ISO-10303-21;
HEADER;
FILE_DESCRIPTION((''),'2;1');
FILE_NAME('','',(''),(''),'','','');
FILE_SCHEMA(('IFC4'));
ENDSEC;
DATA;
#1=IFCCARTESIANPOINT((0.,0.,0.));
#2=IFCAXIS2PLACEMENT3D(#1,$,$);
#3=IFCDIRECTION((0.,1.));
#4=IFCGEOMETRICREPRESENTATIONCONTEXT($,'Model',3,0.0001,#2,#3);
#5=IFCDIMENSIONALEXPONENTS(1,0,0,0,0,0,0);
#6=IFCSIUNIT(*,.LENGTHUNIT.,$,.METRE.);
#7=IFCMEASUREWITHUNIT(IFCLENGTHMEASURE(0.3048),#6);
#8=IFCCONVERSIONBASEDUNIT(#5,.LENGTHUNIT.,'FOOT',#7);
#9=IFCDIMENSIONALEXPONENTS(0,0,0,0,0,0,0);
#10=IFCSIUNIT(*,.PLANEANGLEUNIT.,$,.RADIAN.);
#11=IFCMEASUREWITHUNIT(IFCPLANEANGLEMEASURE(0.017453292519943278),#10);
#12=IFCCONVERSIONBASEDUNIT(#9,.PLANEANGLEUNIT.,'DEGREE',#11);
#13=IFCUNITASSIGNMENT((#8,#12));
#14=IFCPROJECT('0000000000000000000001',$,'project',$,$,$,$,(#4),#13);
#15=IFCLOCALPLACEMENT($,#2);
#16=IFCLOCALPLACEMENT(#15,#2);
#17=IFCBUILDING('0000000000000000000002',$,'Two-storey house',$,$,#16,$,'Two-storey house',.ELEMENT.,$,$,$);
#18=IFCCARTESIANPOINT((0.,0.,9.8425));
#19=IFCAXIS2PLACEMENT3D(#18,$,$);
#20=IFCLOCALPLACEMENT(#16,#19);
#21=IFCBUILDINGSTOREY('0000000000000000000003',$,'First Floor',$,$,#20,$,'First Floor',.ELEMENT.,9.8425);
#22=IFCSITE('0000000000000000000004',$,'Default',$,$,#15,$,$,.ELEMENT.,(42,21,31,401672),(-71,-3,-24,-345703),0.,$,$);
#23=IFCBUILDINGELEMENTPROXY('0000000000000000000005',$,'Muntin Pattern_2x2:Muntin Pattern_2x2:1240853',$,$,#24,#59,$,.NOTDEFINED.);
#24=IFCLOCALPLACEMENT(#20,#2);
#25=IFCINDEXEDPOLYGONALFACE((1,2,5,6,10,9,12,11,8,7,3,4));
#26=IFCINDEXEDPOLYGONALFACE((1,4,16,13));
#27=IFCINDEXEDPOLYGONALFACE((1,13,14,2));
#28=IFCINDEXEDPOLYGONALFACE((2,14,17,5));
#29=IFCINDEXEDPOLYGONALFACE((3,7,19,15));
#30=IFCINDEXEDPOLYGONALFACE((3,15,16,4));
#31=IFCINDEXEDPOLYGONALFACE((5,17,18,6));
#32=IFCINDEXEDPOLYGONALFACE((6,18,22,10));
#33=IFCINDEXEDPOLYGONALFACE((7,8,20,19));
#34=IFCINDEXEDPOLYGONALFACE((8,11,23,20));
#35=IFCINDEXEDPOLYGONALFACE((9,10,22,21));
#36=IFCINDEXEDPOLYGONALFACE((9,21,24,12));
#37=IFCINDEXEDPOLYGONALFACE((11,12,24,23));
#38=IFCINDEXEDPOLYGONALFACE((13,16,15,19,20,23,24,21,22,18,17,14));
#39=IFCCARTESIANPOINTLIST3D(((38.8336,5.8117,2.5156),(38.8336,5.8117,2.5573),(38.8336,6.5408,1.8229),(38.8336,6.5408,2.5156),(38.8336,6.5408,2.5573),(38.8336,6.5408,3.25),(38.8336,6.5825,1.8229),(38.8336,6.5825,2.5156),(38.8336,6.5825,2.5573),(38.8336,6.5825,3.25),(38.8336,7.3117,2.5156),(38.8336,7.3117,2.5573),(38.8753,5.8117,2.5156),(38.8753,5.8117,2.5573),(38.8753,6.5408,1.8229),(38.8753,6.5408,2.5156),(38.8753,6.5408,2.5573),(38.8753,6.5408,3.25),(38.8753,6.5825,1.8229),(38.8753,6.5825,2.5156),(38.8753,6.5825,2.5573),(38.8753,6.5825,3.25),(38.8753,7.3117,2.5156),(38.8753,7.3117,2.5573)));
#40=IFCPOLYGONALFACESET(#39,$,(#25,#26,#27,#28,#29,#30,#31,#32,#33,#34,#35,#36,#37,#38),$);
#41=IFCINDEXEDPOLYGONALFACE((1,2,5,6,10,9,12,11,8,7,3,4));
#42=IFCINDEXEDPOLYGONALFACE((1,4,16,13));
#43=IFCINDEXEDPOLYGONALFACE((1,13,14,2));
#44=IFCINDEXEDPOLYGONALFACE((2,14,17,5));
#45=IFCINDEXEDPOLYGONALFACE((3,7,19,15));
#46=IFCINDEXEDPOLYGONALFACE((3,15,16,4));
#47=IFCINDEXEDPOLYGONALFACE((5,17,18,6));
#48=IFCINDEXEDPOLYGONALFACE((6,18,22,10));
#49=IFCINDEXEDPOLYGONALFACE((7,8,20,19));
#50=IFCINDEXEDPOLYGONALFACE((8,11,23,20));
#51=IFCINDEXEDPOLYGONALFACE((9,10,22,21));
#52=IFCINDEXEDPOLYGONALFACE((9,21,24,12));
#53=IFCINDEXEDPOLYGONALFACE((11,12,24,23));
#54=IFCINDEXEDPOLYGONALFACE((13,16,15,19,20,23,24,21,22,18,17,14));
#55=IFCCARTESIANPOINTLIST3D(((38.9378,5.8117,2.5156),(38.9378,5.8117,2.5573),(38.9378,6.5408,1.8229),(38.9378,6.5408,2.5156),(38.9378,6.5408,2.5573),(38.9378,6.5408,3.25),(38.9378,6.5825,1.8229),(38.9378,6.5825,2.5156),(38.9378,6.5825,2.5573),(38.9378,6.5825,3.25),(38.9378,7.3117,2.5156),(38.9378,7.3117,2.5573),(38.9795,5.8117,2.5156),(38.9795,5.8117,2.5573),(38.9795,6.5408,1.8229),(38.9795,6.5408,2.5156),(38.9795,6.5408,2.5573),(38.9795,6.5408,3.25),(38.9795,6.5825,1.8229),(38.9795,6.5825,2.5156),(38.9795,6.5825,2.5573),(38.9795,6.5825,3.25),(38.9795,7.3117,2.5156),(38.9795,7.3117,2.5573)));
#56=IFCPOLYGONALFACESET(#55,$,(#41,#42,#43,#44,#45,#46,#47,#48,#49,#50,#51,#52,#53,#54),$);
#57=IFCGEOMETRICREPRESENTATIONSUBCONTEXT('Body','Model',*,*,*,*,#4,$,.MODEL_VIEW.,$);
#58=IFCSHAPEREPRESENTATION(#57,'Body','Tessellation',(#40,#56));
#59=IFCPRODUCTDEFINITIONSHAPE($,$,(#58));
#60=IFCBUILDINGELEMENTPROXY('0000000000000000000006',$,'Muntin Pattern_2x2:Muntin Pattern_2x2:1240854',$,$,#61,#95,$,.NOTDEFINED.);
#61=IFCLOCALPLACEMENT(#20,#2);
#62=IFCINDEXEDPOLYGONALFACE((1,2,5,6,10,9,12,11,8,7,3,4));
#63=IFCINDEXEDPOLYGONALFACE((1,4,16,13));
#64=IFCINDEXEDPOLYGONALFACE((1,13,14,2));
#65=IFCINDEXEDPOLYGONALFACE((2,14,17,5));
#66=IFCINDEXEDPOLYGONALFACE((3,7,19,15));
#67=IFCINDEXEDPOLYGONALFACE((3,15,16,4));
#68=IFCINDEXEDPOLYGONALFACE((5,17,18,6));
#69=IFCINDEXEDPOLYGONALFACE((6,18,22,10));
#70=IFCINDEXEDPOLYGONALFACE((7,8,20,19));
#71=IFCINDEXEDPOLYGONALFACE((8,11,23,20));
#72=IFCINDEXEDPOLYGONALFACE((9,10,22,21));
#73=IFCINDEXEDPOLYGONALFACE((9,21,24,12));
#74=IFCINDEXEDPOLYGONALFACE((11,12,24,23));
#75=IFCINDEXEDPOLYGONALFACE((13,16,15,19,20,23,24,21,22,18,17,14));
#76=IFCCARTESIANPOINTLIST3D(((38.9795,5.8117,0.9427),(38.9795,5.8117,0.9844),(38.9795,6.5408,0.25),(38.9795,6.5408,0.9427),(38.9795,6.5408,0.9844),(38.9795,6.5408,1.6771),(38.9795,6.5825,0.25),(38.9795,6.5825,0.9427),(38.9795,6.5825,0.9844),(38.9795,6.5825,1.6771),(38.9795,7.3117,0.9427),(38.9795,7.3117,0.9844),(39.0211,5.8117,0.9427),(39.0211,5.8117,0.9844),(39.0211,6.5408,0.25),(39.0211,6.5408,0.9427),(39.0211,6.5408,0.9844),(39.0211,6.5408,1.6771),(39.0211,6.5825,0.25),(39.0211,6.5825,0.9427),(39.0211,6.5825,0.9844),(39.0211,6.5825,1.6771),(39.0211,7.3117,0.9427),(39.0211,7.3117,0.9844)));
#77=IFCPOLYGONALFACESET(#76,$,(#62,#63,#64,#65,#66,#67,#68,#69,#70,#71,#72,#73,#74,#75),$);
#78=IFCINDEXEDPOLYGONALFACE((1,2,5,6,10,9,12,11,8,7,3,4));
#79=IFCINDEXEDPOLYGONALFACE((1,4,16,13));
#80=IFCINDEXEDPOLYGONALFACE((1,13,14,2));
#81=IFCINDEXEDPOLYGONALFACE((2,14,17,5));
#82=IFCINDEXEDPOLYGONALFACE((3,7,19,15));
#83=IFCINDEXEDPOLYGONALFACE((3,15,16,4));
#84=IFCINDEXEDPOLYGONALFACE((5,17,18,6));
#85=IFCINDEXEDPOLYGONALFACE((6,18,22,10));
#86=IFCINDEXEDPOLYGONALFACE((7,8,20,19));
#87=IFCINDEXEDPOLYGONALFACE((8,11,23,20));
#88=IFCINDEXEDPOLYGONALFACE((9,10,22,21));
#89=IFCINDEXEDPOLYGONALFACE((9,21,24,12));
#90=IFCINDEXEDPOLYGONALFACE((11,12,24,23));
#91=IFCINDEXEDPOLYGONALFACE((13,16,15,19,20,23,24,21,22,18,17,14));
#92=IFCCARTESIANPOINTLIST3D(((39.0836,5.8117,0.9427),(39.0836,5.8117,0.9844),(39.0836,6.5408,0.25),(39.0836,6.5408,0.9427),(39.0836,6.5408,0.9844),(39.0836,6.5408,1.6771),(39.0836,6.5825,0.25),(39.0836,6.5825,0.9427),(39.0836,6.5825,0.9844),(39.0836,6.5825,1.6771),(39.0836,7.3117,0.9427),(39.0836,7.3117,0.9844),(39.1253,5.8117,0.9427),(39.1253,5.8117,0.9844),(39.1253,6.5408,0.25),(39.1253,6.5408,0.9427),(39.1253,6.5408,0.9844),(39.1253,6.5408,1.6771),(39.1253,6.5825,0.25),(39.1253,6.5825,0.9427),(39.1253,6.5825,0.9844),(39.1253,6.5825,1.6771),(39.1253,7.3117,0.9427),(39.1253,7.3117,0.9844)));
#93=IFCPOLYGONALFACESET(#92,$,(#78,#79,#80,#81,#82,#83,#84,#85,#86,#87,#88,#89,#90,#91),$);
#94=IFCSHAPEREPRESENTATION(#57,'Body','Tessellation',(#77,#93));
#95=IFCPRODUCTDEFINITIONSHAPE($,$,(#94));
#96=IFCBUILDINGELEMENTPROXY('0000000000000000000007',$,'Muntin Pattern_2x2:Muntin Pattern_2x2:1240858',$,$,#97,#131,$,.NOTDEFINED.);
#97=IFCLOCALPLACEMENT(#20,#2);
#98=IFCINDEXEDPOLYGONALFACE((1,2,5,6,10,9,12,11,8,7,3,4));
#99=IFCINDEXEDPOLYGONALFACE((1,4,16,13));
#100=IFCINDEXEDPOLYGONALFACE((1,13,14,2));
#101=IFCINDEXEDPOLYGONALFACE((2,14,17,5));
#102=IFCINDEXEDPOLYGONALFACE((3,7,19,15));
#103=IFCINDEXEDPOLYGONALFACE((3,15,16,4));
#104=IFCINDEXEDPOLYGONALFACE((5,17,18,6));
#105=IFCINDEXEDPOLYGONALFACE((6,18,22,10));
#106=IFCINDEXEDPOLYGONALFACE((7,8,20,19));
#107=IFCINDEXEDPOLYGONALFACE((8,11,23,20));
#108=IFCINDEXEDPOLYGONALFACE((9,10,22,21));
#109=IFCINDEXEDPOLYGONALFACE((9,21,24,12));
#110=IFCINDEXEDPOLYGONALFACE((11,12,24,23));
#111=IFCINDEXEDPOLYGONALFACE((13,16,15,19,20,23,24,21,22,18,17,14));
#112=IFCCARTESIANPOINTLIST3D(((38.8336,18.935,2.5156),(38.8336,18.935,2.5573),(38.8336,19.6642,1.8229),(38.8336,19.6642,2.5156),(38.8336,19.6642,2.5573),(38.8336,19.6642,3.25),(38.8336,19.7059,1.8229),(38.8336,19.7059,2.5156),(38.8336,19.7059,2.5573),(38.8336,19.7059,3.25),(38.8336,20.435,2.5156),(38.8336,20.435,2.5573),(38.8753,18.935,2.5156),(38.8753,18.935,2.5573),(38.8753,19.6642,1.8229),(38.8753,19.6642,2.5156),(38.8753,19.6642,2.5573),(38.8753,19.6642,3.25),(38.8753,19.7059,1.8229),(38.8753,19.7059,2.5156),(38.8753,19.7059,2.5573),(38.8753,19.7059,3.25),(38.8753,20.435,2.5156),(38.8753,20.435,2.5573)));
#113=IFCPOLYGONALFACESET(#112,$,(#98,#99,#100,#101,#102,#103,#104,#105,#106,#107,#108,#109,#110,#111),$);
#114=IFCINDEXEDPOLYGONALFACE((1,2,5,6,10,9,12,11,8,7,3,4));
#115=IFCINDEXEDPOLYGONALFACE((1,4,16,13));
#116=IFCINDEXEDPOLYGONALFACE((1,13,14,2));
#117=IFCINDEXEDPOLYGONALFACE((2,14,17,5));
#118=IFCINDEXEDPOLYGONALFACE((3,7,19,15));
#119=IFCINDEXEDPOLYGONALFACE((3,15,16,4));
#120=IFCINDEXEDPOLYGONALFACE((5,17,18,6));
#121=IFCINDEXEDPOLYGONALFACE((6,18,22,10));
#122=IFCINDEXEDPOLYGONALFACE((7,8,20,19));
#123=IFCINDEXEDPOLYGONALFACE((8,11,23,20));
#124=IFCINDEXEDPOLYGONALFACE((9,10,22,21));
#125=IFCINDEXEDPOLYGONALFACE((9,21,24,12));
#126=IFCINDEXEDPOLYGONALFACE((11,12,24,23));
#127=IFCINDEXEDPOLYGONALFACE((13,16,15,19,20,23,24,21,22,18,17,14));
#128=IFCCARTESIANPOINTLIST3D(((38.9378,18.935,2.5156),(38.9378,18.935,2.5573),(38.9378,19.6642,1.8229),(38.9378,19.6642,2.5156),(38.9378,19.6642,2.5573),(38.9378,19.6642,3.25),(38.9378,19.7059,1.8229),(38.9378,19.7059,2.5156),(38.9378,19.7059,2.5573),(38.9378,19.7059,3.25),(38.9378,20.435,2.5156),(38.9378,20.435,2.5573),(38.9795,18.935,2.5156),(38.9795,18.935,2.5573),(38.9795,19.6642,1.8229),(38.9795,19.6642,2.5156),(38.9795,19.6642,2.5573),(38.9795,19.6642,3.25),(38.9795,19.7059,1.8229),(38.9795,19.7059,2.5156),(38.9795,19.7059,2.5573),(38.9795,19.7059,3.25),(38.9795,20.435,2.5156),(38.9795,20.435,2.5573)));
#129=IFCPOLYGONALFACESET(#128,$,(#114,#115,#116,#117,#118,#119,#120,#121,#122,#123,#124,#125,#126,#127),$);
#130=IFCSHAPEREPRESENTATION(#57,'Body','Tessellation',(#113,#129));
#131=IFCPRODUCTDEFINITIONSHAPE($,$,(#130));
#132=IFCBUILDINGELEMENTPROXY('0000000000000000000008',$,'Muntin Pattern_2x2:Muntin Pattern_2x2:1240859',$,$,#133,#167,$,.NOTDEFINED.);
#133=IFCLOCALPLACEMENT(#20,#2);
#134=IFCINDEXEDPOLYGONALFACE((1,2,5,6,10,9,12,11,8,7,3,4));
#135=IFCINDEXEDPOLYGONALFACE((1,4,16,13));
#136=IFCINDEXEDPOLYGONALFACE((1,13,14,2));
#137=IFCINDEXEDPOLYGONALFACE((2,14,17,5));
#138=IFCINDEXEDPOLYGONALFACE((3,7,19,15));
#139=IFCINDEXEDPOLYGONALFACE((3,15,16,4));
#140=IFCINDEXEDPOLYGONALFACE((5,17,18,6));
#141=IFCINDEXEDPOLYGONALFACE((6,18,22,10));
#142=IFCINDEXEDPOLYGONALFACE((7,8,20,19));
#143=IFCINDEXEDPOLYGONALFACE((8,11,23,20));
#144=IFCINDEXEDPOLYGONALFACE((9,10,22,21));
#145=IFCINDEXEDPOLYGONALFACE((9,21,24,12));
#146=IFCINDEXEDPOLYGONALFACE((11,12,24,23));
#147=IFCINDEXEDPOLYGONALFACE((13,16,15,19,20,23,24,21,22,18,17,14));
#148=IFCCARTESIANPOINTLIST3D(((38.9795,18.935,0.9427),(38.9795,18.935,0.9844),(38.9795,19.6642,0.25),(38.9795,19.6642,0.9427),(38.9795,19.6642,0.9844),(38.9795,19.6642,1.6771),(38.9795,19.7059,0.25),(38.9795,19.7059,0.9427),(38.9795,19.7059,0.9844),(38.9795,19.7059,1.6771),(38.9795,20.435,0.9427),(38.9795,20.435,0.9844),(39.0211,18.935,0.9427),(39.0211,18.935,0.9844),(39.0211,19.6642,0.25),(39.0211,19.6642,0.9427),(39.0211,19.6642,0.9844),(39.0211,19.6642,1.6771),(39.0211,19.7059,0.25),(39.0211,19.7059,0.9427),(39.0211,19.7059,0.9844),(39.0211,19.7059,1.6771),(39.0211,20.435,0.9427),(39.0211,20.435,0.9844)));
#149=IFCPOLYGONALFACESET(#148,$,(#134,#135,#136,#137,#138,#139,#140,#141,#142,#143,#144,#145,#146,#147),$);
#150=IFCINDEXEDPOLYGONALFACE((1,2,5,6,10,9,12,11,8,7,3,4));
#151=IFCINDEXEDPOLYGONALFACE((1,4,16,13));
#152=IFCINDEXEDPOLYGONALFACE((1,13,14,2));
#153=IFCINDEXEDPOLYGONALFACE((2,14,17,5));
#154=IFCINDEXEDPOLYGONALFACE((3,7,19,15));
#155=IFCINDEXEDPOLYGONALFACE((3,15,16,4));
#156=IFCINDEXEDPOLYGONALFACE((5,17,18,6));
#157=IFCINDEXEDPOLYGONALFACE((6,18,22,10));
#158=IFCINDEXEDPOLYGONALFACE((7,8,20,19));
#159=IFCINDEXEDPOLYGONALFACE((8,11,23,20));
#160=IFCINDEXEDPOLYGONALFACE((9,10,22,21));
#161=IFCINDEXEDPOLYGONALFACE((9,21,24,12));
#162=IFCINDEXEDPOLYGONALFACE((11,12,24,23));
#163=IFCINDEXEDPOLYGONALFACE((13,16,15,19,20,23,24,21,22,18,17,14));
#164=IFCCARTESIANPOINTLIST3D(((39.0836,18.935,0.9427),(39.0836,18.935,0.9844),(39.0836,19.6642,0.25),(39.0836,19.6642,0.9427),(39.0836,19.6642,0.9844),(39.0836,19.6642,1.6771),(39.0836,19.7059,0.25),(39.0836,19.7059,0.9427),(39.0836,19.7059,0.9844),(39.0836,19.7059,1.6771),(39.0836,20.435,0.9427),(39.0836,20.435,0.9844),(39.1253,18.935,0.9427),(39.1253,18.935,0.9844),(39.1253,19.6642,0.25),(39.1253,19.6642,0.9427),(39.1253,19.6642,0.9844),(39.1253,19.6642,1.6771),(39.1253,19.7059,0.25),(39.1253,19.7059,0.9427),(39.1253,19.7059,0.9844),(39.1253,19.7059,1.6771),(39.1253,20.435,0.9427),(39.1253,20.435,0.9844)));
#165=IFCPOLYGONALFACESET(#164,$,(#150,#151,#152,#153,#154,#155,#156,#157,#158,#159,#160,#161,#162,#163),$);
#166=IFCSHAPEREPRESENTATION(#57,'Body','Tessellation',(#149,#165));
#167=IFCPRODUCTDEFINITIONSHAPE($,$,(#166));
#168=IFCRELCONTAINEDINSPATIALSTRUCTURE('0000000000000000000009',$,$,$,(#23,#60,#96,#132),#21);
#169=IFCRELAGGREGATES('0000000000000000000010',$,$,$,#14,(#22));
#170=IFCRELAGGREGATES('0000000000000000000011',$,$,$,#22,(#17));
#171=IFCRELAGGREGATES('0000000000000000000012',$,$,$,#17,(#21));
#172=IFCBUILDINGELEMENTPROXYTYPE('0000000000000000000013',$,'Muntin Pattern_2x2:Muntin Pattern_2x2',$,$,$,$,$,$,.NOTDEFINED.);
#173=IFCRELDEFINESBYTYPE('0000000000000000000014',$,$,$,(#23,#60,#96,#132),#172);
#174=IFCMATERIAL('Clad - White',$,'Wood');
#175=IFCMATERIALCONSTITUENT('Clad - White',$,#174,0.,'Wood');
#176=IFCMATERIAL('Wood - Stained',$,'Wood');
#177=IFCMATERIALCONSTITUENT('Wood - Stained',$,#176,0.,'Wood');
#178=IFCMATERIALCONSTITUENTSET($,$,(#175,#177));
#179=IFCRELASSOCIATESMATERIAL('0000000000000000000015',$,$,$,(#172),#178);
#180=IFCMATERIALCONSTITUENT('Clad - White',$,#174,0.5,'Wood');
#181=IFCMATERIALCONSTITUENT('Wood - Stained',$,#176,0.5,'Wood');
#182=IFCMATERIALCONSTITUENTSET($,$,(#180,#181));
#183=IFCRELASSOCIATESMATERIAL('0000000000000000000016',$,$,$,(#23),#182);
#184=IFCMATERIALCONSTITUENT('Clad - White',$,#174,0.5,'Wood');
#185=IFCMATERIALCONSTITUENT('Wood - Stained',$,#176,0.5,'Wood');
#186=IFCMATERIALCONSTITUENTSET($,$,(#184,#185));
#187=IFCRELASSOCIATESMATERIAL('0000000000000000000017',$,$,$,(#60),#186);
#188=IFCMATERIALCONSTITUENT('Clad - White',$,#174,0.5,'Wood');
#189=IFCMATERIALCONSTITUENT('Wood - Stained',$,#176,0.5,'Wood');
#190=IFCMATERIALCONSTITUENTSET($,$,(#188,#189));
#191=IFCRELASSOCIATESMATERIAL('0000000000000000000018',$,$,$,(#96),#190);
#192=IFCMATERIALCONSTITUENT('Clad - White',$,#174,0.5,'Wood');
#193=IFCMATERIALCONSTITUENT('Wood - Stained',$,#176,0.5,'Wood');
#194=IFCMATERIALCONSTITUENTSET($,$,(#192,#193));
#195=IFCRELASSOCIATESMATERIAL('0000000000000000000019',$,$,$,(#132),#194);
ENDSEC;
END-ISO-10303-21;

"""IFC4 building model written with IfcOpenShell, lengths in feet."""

from ifc_helpers import new_model, entity, si_unit, converted_unit, direction, frame, origin, place, context, subcontext, project, spatial, indexed_curve, outline, extrude, source, transform, mapped, material, constituent, constituent_set, type_object, type_shapes, element, save


model = new_model("IFC4")

# Units and contexts
model_context = context("Model", 3, precision=0.0001, world=origin(), true_north=direction((0.0, 1.0)))
body_context = subcontext(model_context, "Body", "Model", "MODEL_VIEW")
ifc_project = project(units=[converted_unit("LENGTHUNIT", "FOOT", entity("IfcLengthMeasure", 0.3048), si_unit("LENGTHUNIT", "METRE"), dimensions=[1, 0, 0, 0, 0, 0, 0]), converted_unit("PLANEANGLEUNIT", "DEGREE", entity("IfcPlaneAngleMeasure", 0.017453292519943278), si_unit("PLANEANGLEUNIT", "RADIAN"), dimensions=[0, 0, 0, 0, 0, 0, 0])], contexts=[model_context])

# Site, building, storey
site_placement = place(None, origin())
site = spatial("IfcSite", under=ifc_project, at=site_placement, Name="Default", CompositionType="ELEMENT", RefLatitude=(42, 21, 31, 401672), RefLongitude=(-71, -3, -24, -345703), RefElevation=0.0)
building_placement = place(site_placement, origin())
building = spatial("IfcBuilding", under=site, at=building_placement, Name="Two-storey house", LongName="Two-storey house", CompositionType="ELEMENT")
storey_placement = place(building_placement, frame((0.0, 0.0, 9.8425)))
storey = spatial("IfcBuildingStorey", under=building, at=storey_placement, Name="First Floor", LongName="First Floor", CompositionType="ELEMENT", Elevation=9.8425)

# Shared definitions
ifc_material_1 = material(Name="Wood - Stained", Category="Wood")

# Building element proxies
ifc_material_2 = material(Name="Clad - White", Category="Wood")
ifc_constituent_1 = constituent(ifc_material_2, Name="Clad - White", Category="Wood", fraction=0.5)
ifc_constituent_2 = constituent(ifc_material_1, Name="Wood - Stained", Category="Wood", fraction=0.5)
ifc_constituent_set_1 = constituent_set(constituents=[ifc_constituent_1, ifc_constituent_2])
ifc_constituent_3 = constituent(ifc_material_2, Name="Clad - White", Category="Wood", fraction=0.0)
ifc_constituent_4 = constituent(ifc_material_1, Name="Wood - Stained", Category="Wood", fraction=0.0)
ifc_constituent_set_2 = constituent_set(constituents=[ifc_constituent_3, ifc_constituent_4])
building_element_proxy_type_1 = type_object("IfcBuildingElementProxyType", Name="Muntin Pattern_2x2:Muntin Pattern_2x2", PredefinedType="NOTDEFINED", material=ifc_constituent_set_2)
shared_shape_1 = source(origin(), body_context, "Body", "SweptSolid", [
    extrude(outline(indexed_curve([(0.0208, -0.0208), (0.7135, -0.0208), (0.7135, 0.0208), (0.0208, 0.0208), (0.0208, 0.75), (-0.0208, 0.75), (-0.0208, 0.0208), (-0.7135, 0.0208), (-0.7135, -0.0208), (-0.0208, -0.0208), (-0.0208, -0.75), (0.0208, -0.75), (0.0208, -0.0208)], self_intersect=False)), frame((0.0, 0.0312, 0.7135), z_axis=(0.0, 1.0, 0.0), x_axis=(0.0, 0.0, 1.0)), (0.0, 0.0, 1.0), 0.0417),
    extrude(outline(indexed_curve([(0.0208, -0.0208), (0.7135, -0.0208), (0.7135, 0.0208), (0.0208, 0.0208), (0.0208, 0.75), (-0.0208, 0.75), (-0.0208, 0.0208), (-0.7135, 0.0208), (-0.7135, -0.0208), (-0.0208, -0.0208), (-0.0208, -0.75), (0.0208, -0.75), (0.0208, -0.0208)], self_intersect=False)), frame((0.0, -0.0729, 0.7135), z_axis=(0.0, 1.0, 0.0), x_axis=(0.0, 0.0, 1.0)), (0.0, 0.0, 1.0), 0.0417),
])
type_shapes(building_element_proxy_type_1, [shared_shape_1])
proxy_1_placement = place(storey_placement, frame((38.9065, 6.5617, 1.8229), z_axis=(0.0, 0.0, 1.0), x_axis=(0.0, 1.0, 0.0)))
element("IfcBuildingElementProxy", 1, at=proxy_1_placement, inside=storey, type_object=building_element_proxy_type_1, material=ifc_constituent_set_1, Name="Muntin Pattern_2x2:Muntin Pattern_2x2:1240853", PredefinedType="NOTDEFINED", context=body_context, shape_type="MappedRepresentation", body=[
    mapped(shared_shape_1, transform((0.0, 0.0, 0.0), scale=1.0)),
])
ifc_constituent_5 = constituent(ifc_material_2, Name="Clad - White", Category="Wood", fraction=0.5)
ifc_constituent_6 = constituent(ifc_material_1, Name="Wood - Stained", Category="Wood", fraction=0.5)
ifc_constituent_set_3 = constituent_set(constituents=[ifc_constituent_5, ifc_constituent_6])
proxy_2_placement = place(storey_placement, frame((39.0524, 6.5617, 0.25), z_axis=(0.0, 0.0, 1.0), x_axis=(0.0, 1.0, 0.0)))
element("IfcBuildingElementProxy", 2, at=proxy_2_placement, inside=storey, type_object=building_element_proxy_type_1, material=ifc_constituent_set_3, Name="Muntin Pattern_2x2:Muntin Pattern_2x2:1240854", PredefinedType="NOTDEFINED", context=body_context, shape_type="MappedRepresentation", body=[
    mapped(shared_shape_1, transform((0.0, 0.0, 0.0), scale=1.0)),
])
ifc_constituent_7 = constituent(ifc_material_2, Name="Clad - White", Category="Wood", fraction=0.5)
ifc_constituent_8 = constituent(ifc_material_1, Name="Wood - Stained", Category="Wood", fraction=0.5)
ifc_constituent_set_4 = constituent_set(constituents=[ifc_constituent_7, ifc_constituent_8])
proxy_3_placement = place(storey_placement, frame((38.9065, 19.685, 1.8229), z_axis=(0.0, 0.0, 1.0), x_axis=(0.0, 1.0, 0.0)))
element("IfcBuildingElementProxy", 3, at=proxy_3_placement, inside=storey, type_object=building_element_proxy_type_1, material=ifc_constituent_set_4, Name="Muntin Pattern_2x2:Muntin Pattern_2x2:1240858", PredefinedType="NOTDEFINED", context=body_context, shape_type="MappedRepresentation", body=[
    mapped(shared_shape_1, transform((0.0, 0.0, 0.0), scale=1.0)),
])
ifc_constituent_9 = constituent(ifc_material_2, Name="Clad - White", Category="Wood", fraction=0.5)
ifc_constituent_10 = constituent(ifc_material_1, Name="Wood - Stained", Category="Wood", fraction=0.5)
ifc_constituent_set_5 = constituent_set(constituents=[ifc_constituent_9, ifc_constituent_10])
proxy_4_placement = place(storey_placement, frame((39.0524, 19.685, 0.25), z_axis=(0.0, 0.0, 1.0), x_axis=(0.0, 1.0, 0.0)))
element("IfcBuildingElementProxy", 4, at=proxy_4_placement, inside=storey, type_object=building_element_proxy_type_1, material=ifc_constituent_set_5, Name="Muntin Pattern_2x2:Muntin Pattern_2x2:1240859", PredefinedType="NOTDEFINED", context=body_context, shape_type="MappedRepresentation", body=[
    mapped(shared_shape_1, transform((0.0, 0.0, 0.0), scale=1.0)),
])

save(model, "model.ifc")
